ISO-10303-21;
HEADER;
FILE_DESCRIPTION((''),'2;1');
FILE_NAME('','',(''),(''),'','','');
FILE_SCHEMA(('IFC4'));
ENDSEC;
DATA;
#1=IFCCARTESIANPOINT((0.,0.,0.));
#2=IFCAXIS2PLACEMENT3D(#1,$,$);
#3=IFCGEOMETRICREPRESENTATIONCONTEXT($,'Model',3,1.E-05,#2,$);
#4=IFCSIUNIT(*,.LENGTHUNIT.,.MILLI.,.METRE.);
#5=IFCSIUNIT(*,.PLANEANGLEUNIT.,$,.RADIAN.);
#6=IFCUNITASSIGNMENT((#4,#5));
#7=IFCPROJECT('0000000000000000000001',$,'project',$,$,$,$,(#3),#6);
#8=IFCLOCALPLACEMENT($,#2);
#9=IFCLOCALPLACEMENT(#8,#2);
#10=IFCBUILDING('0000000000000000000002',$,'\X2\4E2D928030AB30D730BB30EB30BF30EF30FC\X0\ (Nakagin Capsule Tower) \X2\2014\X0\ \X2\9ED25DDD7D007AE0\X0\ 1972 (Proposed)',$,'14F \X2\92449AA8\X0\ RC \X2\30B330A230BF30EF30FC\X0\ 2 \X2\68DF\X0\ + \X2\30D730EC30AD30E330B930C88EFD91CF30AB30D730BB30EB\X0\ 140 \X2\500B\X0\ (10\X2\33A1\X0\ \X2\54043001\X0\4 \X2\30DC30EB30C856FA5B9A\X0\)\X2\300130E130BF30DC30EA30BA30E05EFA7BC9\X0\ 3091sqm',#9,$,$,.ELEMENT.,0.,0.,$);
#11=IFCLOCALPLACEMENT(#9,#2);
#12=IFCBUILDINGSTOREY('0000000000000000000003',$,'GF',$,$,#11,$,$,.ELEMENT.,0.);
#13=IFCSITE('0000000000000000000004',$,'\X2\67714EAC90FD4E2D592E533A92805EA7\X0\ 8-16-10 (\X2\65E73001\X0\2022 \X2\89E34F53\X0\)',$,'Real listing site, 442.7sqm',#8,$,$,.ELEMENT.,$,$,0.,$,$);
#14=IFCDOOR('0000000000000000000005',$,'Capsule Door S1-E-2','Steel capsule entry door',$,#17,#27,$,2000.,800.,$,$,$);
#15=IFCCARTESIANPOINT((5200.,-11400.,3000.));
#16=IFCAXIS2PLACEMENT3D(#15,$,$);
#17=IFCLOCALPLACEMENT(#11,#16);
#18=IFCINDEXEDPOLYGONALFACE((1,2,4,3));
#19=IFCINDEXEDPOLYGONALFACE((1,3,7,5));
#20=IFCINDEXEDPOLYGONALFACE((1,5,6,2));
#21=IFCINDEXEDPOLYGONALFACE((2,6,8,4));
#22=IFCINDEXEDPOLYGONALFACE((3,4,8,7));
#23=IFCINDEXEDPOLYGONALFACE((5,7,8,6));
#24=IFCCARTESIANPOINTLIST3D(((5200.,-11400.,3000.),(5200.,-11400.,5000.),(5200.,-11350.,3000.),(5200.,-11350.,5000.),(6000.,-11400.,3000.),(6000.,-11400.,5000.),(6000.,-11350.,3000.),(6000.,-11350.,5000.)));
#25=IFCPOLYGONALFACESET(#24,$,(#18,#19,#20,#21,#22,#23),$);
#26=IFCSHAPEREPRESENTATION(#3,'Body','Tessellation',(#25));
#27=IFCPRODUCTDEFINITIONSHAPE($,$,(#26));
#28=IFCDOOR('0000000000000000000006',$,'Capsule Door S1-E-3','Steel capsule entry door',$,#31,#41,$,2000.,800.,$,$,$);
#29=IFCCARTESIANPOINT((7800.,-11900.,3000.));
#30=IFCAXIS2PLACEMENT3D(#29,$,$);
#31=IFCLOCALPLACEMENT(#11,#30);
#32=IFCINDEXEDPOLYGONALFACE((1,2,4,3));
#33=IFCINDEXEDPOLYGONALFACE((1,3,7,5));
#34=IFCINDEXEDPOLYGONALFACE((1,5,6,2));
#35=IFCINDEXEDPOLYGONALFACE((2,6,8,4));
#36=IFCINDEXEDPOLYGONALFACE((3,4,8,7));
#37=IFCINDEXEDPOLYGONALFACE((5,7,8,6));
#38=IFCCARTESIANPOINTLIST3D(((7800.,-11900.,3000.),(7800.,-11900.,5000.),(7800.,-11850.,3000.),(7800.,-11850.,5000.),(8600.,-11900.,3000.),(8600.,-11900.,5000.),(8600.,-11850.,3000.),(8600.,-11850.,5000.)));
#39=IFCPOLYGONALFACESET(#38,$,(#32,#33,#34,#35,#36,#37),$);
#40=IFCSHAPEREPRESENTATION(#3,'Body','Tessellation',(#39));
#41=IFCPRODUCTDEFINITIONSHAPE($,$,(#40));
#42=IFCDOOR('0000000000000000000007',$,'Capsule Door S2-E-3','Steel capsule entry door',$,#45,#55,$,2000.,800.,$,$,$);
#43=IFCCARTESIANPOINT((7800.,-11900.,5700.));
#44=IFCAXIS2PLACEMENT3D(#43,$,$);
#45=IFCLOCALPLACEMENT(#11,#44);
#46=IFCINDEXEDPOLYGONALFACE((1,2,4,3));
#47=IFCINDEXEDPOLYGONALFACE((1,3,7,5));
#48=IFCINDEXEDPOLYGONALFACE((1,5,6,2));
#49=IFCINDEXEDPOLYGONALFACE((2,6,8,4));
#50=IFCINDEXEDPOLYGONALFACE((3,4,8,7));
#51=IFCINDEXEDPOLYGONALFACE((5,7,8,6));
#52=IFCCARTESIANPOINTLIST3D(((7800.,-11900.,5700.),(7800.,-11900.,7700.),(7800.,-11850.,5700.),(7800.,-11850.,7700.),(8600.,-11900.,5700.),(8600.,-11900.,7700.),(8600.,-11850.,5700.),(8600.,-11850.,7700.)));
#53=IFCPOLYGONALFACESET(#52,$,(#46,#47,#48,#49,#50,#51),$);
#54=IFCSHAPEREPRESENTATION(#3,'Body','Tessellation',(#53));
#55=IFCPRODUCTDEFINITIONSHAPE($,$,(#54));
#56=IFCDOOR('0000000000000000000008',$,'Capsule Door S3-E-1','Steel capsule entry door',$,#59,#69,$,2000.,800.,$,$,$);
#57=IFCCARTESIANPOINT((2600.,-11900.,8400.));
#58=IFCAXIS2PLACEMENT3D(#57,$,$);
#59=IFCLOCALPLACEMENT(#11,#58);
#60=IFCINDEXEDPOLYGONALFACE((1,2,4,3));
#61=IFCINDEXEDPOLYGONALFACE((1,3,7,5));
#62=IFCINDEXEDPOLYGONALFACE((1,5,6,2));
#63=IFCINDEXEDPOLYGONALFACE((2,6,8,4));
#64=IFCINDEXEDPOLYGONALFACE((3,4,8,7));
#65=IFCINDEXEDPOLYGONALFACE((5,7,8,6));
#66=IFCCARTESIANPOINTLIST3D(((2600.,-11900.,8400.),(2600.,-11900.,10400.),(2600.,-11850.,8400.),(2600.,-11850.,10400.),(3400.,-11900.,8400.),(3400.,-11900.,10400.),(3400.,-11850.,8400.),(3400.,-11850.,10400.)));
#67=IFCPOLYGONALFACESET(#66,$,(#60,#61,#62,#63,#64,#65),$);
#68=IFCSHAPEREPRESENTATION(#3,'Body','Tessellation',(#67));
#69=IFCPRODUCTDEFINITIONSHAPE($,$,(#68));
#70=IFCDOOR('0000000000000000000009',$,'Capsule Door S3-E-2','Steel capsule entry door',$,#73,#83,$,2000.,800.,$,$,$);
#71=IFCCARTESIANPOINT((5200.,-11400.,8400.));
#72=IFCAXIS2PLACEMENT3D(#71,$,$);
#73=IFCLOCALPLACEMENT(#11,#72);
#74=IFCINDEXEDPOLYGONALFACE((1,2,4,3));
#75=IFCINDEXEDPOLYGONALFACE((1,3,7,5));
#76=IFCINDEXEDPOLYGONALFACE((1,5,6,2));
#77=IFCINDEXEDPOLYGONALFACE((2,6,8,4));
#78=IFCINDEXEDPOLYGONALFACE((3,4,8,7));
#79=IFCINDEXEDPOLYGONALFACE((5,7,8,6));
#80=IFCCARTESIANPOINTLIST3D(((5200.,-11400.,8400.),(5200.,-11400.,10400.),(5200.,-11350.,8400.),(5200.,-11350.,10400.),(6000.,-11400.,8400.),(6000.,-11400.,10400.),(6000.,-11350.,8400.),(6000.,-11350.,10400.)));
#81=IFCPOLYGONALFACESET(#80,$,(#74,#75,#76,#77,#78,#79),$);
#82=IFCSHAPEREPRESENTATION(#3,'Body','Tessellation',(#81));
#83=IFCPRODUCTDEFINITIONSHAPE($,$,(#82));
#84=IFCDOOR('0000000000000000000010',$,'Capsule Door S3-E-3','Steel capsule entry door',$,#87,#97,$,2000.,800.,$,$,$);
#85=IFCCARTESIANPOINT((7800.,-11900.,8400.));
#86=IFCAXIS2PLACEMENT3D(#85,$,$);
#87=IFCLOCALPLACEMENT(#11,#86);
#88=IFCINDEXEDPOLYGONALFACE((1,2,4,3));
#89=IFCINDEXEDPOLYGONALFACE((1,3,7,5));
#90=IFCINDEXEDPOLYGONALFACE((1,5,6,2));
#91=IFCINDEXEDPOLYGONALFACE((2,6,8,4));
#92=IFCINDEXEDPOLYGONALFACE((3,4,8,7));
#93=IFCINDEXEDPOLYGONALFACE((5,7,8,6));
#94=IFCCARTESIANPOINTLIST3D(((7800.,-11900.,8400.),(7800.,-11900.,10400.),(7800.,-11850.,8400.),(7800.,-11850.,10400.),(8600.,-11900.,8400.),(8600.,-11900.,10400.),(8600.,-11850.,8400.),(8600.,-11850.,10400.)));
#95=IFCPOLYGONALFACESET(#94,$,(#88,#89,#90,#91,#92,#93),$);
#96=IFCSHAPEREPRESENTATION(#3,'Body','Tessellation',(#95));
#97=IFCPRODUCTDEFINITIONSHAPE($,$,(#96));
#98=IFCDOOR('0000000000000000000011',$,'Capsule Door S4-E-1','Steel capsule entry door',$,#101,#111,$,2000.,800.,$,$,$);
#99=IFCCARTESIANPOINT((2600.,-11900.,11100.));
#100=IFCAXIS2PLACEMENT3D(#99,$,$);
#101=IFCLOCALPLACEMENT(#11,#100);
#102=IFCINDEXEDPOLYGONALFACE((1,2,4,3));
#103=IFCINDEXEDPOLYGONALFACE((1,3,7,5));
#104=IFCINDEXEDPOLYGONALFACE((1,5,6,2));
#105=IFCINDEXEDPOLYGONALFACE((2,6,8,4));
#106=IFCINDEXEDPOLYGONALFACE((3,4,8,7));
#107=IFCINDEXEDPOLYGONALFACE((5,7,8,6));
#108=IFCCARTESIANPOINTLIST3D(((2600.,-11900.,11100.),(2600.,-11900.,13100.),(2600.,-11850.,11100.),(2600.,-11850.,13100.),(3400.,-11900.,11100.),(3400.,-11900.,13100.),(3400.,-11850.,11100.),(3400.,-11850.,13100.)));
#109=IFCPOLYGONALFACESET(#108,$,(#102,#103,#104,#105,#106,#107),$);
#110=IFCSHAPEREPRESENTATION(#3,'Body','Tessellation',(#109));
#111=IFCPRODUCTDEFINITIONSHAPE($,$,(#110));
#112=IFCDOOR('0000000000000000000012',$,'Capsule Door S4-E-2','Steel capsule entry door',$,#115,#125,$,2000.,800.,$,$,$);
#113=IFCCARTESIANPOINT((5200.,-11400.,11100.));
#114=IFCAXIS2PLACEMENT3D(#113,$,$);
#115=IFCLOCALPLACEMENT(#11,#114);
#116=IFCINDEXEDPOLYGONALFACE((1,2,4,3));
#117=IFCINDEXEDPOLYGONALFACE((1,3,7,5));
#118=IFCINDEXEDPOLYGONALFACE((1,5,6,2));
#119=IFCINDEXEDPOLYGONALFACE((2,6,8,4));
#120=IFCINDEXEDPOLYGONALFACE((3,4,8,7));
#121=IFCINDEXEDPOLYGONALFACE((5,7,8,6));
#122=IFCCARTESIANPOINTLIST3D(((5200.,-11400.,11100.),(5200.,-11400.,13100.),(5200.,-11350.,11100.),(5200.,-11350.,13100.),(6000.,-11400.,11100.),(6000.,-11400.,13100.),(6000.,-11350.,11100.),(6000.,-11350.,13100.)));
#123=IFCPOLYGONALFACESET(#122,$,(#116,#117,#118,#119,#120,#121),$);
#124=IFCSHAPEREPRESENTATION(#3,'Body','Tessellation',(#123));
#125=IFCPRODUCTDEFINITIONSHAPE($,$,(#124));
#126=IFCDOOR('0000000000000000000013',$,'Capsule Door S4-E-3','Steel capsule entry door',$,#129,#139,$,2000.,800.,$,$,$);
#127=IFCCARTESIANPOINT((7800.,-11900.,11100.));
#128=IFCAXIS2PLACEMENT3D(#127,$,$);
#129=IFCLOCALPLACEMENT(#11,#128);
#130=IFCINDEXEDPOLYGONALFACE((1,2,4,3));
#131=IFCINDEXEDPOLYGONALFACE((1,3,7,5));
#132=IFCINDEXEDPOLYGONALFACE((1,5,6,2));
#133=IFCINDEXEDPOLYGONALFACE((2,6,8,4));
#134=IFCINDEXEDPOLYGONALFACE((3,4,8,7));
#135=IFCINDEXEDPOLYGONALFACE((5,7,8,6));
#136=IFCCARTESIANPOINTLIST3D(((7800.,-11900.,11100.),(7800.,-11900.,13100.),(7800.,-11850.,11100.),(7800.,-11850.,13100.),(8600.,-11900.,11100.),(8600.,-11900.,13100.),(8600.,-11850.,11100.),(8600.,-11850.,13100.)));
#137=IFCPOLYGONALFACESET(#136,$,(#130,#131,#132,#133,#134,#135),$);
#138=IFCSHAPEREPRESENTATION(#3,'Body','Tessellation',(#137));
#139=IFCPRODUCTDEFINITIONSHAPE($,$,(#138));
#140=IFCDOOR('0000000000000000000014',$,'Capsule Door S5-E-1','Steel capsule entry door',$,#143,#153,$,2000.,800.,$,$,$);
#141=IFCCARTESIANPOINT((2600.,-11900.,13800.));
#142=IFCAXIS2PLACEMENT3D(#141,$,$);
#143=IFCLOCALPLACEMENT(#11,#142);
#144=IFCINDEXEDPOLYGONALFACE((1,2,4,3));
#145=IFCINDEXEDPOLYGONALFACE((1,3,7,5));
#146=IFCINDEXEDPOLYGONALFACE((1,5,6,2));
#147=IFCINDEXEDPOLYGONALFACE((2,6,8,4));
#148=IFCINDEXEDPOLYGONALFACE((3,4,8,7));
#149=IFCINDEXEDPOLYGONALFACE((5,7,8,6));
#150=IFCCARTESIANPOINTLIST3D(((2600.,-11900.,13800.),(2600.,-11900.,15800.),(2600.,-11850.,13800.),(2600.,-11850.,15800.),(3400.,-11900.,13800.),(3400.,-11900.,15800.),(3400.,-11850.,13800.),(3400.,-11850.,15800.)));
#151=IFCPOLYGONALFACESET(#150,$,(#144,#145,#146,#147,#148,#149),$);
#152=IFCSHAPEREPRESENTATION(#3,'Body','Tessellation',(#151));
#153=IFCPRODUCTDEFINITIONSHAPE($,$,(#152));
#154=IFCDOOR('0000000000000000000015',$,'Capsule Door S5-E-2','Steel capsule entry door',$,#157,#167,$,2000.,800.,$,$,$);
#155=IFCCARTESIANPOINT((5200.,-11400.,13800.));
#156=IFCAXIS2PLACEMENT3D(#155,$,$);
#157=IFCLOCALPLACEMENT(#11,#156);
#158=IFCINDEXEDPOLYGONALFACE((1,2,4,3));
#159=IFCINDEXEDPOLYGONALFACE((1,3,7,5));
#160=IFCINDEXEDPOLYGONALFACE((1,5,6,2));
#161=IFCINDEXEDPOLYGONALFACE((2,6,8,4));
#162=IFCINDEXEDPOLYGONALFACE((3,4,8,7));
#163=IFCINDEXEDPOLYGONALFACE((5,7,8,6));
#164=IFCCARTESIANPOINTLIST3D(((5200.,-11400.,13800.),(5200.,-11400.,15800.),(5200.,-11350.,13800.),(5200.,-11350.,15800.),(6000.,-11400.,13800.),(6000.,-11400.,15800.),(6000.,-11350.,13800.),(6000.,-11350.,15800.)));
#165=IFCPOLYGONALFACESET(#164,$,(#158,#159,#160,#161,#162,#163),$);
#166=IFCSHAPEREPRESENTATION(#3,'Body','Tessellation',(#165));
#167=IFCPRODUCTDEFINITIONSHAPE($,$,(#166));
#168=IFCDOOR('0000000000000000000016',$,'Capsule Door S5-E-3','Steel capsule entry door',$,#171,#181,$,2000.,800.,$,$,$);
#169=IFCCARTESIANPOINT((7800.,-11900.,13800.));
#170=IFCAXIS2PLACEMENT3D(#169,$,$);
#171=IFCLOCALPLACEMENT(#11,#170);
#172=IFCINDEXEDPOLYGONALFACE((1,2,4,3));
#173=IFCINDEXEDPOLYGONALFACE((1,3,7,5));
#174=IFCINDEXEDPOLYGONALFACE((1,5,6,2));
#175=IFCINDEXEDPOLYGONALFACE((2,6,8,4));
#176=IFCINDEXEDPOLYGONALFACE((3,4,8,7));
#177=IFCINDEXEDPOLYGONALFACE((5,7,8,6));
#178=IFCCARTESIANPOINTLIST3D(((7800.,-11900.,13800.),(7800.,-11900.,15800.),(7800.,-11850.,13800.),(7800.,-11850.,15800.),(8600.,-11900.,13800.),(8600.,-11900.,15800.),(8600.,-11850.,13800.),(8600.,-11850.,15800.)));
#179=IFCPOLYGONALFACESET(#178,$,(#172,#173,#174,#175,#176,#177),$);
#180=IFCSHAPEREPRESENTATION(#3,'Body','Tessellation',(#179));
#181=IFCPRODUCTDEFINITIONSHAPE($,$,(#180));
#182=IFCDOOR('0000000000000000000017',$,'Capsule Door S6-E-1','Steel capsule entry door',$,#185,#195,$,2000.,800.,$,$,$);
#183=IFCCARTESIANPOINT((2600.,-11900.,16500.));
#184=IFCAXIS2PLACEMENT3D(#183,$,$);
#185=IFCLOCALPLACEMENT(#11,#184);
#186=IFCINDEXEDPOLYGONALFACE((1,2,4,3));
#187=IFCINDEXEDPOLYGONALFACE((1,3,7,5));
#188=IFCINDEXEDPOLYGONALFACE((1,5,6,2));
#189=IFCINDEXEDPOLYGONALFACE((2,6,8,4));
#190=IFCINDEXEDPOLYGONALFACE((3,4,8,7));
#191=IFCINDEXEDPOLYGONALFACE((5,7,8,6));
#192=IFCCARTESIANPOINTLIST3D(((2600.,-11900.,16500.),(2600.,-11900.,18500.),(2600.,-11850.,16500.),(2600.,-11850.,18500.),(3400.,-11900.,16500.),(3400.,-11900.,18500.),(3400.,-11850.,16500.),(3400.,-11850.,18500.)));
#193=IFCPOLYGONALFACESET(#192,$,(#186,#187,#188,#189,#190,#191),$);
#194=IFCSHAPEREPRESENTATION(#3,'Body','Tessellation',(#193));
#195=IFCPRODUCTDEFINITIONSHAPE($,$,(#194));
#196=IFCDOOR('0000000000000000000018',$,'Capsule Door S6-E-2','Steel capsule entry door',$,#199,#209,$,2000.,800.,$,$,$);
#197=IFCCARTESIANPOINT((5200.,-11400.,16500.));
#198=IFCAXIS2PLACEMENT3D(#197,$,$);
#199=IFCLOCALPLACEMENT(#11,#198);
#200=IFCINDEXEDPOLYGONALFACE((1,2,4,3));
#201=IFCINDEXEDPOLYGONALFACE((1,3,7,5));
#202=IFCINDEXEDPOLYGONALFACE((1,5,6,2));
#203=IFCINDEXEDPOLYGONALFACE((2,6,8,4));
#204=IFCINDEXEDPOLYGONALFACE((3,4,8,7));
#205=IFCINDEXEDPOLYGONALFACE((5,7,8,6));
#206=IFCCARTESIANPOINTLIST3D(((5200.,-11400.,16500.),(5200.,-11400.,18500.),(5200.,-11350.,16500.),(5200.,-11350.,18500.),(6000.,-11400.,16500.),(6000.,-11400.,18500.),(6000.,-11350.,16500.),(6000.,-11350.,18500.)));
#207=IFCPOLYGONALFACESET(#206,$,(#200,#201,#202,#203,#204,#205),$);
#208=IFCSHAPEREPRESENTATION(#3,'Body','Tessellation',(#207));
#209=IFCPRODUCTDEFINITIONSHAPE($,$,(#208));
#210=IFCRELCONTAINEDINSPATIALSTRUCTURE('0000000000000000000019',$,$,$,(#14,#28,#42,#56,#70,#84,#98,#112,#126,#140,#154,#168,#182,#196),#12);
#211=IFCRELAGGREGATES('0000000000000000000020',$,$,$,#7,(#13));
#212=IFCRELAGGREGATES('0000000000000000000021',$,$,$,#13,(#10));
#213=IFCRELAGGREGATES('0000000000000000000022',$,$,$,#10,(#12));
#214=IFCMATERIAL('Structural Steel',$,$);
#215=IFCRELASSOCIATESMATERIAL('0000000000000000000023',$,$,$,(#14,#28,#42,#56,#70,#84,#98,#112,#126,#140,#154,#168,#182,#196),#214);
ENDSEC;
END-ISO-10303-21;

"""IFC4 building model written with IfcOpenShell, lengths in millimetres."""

from ifc_helpers import new_model, si_unit, frame, frame_2d, origin, place, context, project, spatial, rectangle, extrude, material, element, save


model = new_model("IFC4")

# Units and contexts
model_context = context("Model", 3, precision=1e-05, world=origin())
ifc_project = project(units=[si_unit("LENGTHUNIT", "METRE", prefix="MILLI"), si_unit("PLANEANGLEUNIT", "RADIAN")], contexts=[model_context])

# Site, building, storey
site_placement = place(None, origin())
site = spatial("IfcSite", under=ifc_project, at=site_placement, Name="東京都中央区銀座 8-16-10 (旧、2022 解体)", ObjectType="Real listing site, 442.7sqm", CompositionType="ELEMENT", RefElevation=0.0)
building_placement = place(site_placement, origin())
building = spatial("IfcBuilding", under=site, at=building_placement, Name="中銀カプセルタワー (Nakagin Capsule Tower) — 黒川紀章 1972 (Proposed)", ObjectType="14F 鉄骨 RC コアタワー 2 棟 + プレキャスト軽量カプセル 140 個 (10㎡ 各、4 ボルト固定)、メタボリズム建築 3091sqm", CompositionType="ELEMENT", ElevationOfRefHeight=0.0, ElevationOfTerrain=0.0)
storey_placement = place(building_placement, origin())
storey = spatial("IfcBuildingStorey", under=building, at=storey_placement, Name="GF", CompositionType="ELEMENT", Elevation=0.0)

# Doors
ifc_material_1 = material(Name="Structural Steel")
door_1_placement = place(storey_placement, frame((5200.0, -11400.0, 3000.0)))
element("IfcDoor", 1, at=door_1_placement, inside=storey, material=ifc_material_1, Name="Capsule Door S1-E-2", Description="Steel capsule entry door", OverallHeight=2000.0, OverallWidth=800.0, context=model_context, shape_type="SweptSolid", body=[
    extrude(rectangle(XDim=800.0, YDim=50.0, at=frame_2d((400.0, 25.0))), frame((5200.0, -11400.0, 3000.0)), (0.0, 0.0, 1.0), 2000.0),
])
door_2_placement = place(storey_placement, frame((7800.0, -11900.0, 3000.0)))
element("IfcDoor", 2, at=door_2_placement, inside=storey, material=ifc_material_1, Name="Capsule Door S1-E-3", Description="Steel capsule entry door", OverallHeight=2000.0, OverallWidth=800.0, context=model_context, shape_type="SweptSolid", body=[
    extrude(rectangle(XDim=800.0, YDim=50.0, at=frame_2d((400.0, 25.0))), frame((7800.0, -11900.0, 3000.0)), (0.0, 0.0, 1.0), 2000.0),
])
door_3_placement = place(storey_placement, frame((7800.0, -11900.0, 5700.0)))
element("IfcDoor", 3, at=door_3_placement, inside=storey, material=ifc_material_1, Name="Capsule Door S2-E-3", Description="Steel capsule entry door", OverallHeight=2000.0, OverallWidth=800.0, context=model_context, shape_type="SweptSolid", body=[
    extrude(rectangle(XDim=800.0, YDim=50.0, at=frame_2d((400.0, 25.0))), frame((7800.0, -11900.0, 5700.0)), (0.0, 0.0, 1.0), 2000.0),
])
door_4_placement = place(storey_placement, frame((2600.0, -11900.0, 8400.0)))
element("IfcDoor", 4, at=door_4_placement, inside=storey, material=ifc_material_1, Name="Capsule Door S3-E-1", Description="Steel capsule entry door", OverallHeight=2000.0, OverallWidth=800.0, context=model_context, shape_type="SweptSolid", body=[
    extrude(rectangle(XDim=800.0, YDim=50.0, at=frame_2d((400.0, 25.0))), frame((2600.0, -11900.0, 8400.0)), (0.0, 0.0, 1.0), 2000.0),
])
door_5_placement = place(storey_placement, frame((5200.0, -11400.0, 8400.0)))
element("IfcDoor", 5, at=door_5_placement, inside=storey, material=ifc_material_1, Name="Capsule Door S3-E-2", Description="Steel capsule entry door", OverallHeight=2000.0, OverallWidth=800.0, context=model_context, shape_type="SweptSolid", body=[
    extrude(rectangle(XDim=800.0, YDim=50.0, at=frame_2d((400.0, 25.0))), frame((5200.0, -11400.0, 8400.0)), (0.0, 0.0, 1.0), 2000.0),
])
door_6_placement = place(storey_placement, frame((7800.0, -11900.0, 8400.0)))
element("IfcDoor", 6, at=door_6_placement, inside=storey, material=ifc_material_1, Name="Capsule Door S3-E-3", Description="Steel capsule entry door", OverallHeight=2000.0, OverallWidth=800.0, context=model_context, shape_type="SweptSolid", body=[
    extrude(rectangle(XDim=800.0, YDim=50.0, at=frame_2d((400.0, 25.0))), frame((7800.0, -11900.0, 8400.0)), (0.0, 0.0, 1.0), 2000.0),
])
door_7_placement = place(storey_placement, frame((2600.0, -11900.0, 11100.0)))
element("IfcDoor", 7, at=door_7_placement, inside=storey, material=ifc_material_1, Name="Capsule Door S4-E-1", Description="Steel capsule entry door", OverallHeight=2000.0, OverallWidth=800.0, context=model_context, shape_type="SweptSolid", body=[
    extrude(rectangle(XDim=800.0, YDim=50.0, at=frame_2d((400.0, 25.0))), frame((2600.0, -11900.0, 11100.0)), (0.0, 0.0, 1.0), 2000.0),
])
door_8_placement = place(storey_placement, frame((5200.0, -11400.0, 11100.0)))
element("IfcDoor", 8, at=door_8_placement, inside=storey, material=ifc_material_1, Name="Capsule Door S4-E-2", Description="Steel capsule entry door", OverallHeight=2000.0, OverallWidth=800.0, context=model_context, shape_type="SweptSolid", body=[
    extrude(rectangle(XDim=800.0, YDim=50.0, at=frame_2d((400.0, 25.0))), frame((5200.0, -11400.0, 11100.0)), (0.0, 0.0, 1.0), 2000.0),
])
door_9_placement = place(storey_placement, frame((7800.0, -11900.0, 11100.0)))
element("IfcDoor", 9, at=door_9_placement, inside=storey, material=ifc_material_1, Name="Capsule Door S4-E-3", Description="Steel capsule entry door", OverallHeight=2000.0, OverallWidth=800.0, context=model_context, shape_type="SweptSolid", body=[
    extrude(rectangle(XDim=800.0, YDim=50.0, at=frame_2d((400.0, 25.0))), frame((7800.0, -11900.0, 11100.0)), (0.0, 0.0, 1.0), 2000.0),
])
door_10_placement = place(storey_placement, frame((2600.0, -11900.0, 13800.0)))
element("IfcDoor", 10, at=door_10_placement, inside=storey, material=ifc_material_1, Name="Capsule Door S5-E-1", Description="Steel capsule entry door", OverallHeight=2000.0, OverallWidth=800.0, context=model_context, shape_type="SweptSolid", body=[
    extrude(rectangle(XDim=800.0, YDim=50.0, at=frame_2d((400.0, 25.0))), frame((2600.0, -11900.0, 13800.0)), (0.0, 0.0, 1.0), 2000.0),
])
door_11_placement = place(storey_placement, frame((5200.0, -11400.0, 13800.0)))
element("IfcDoor", 11, at=door_11_placement, inside=storey, material=ifc_material_1, Name="Capsule Door S5-E-2", Description="Steel capsule entry door", OverallHeight=2000.0, OverallWidth=800.0, context=model_context, shape_type="SweptSolid", body=[
    extrude(rectangle(XDim=800.0, YDim=50.0, at=frame_2d((400.0, 25.0))), frame((5200.0, -11400.0, 13800.0)), (0.0, 0.0, 1.0), 2000.0),
])
door_12_placement = place(storey_placement, frame((7800.0, -11900.0, 13800.0)))
element("IfcDoor", 12, at=door_12_placement, inside=storey, material=ifc_material_1, Name="Capsule Door S5-E-3", Description="Steel capsule entry door", OverallHeight=2000.0, OverallWidth=800.0, context=model_context, shape_type="SweptSolid", body=[
    extrude(rectangle(XDim=800.0, YDim=50.0, at=frame_2d((400.0, 25.0))), frame((7800.0, -11900.0, 13800.0)), (0.0, 0.0, 1.0), 2000.0),
])
door_13_placement = place(storey_placement, frame((2600.0, -11900.0, 16500.0)))
element("IfcDoor", 13, at=door_13_placement, inside=storey, material=ifc_material_1, Name="Capsule Door S6-E-1", Description="Steel capsule entry door", OverallHeight=2000.0, OverallWidth=800.0, context=model_context, shape_type="SweptSolid", body=[
    extrude(rectangle(XDim=800.0, YDim=50.0, at=frame_2d((400.0, 25.0))), frame((2600.0, -11900.0, 16500.0)), (0.0, 0.0, 1.0), 2000.0),
])
door_14_placement = place(storey_placement, frame((5200.0, -11400.0, 16500.0)))
element("IfcDoor", 14, at=door_14_placement, inside=storey, material=ifc_material_1, Name="Capsule Door S6-E-2", Description="Steel capsule entry door", OverallHeight=2000.0, OverallWidth=800.0, context=model_context, shape_type="SweptSolid", body=[
    extrude(rectangle(XDim=800.0, YDim=50.0, at=frame_2d((400.0, 25.0))), frame((5200.0, -11400.0, 16500.0)), (0.0, 0.0, 1.0), 2000.0),
])

save(model, "model.ifc")
